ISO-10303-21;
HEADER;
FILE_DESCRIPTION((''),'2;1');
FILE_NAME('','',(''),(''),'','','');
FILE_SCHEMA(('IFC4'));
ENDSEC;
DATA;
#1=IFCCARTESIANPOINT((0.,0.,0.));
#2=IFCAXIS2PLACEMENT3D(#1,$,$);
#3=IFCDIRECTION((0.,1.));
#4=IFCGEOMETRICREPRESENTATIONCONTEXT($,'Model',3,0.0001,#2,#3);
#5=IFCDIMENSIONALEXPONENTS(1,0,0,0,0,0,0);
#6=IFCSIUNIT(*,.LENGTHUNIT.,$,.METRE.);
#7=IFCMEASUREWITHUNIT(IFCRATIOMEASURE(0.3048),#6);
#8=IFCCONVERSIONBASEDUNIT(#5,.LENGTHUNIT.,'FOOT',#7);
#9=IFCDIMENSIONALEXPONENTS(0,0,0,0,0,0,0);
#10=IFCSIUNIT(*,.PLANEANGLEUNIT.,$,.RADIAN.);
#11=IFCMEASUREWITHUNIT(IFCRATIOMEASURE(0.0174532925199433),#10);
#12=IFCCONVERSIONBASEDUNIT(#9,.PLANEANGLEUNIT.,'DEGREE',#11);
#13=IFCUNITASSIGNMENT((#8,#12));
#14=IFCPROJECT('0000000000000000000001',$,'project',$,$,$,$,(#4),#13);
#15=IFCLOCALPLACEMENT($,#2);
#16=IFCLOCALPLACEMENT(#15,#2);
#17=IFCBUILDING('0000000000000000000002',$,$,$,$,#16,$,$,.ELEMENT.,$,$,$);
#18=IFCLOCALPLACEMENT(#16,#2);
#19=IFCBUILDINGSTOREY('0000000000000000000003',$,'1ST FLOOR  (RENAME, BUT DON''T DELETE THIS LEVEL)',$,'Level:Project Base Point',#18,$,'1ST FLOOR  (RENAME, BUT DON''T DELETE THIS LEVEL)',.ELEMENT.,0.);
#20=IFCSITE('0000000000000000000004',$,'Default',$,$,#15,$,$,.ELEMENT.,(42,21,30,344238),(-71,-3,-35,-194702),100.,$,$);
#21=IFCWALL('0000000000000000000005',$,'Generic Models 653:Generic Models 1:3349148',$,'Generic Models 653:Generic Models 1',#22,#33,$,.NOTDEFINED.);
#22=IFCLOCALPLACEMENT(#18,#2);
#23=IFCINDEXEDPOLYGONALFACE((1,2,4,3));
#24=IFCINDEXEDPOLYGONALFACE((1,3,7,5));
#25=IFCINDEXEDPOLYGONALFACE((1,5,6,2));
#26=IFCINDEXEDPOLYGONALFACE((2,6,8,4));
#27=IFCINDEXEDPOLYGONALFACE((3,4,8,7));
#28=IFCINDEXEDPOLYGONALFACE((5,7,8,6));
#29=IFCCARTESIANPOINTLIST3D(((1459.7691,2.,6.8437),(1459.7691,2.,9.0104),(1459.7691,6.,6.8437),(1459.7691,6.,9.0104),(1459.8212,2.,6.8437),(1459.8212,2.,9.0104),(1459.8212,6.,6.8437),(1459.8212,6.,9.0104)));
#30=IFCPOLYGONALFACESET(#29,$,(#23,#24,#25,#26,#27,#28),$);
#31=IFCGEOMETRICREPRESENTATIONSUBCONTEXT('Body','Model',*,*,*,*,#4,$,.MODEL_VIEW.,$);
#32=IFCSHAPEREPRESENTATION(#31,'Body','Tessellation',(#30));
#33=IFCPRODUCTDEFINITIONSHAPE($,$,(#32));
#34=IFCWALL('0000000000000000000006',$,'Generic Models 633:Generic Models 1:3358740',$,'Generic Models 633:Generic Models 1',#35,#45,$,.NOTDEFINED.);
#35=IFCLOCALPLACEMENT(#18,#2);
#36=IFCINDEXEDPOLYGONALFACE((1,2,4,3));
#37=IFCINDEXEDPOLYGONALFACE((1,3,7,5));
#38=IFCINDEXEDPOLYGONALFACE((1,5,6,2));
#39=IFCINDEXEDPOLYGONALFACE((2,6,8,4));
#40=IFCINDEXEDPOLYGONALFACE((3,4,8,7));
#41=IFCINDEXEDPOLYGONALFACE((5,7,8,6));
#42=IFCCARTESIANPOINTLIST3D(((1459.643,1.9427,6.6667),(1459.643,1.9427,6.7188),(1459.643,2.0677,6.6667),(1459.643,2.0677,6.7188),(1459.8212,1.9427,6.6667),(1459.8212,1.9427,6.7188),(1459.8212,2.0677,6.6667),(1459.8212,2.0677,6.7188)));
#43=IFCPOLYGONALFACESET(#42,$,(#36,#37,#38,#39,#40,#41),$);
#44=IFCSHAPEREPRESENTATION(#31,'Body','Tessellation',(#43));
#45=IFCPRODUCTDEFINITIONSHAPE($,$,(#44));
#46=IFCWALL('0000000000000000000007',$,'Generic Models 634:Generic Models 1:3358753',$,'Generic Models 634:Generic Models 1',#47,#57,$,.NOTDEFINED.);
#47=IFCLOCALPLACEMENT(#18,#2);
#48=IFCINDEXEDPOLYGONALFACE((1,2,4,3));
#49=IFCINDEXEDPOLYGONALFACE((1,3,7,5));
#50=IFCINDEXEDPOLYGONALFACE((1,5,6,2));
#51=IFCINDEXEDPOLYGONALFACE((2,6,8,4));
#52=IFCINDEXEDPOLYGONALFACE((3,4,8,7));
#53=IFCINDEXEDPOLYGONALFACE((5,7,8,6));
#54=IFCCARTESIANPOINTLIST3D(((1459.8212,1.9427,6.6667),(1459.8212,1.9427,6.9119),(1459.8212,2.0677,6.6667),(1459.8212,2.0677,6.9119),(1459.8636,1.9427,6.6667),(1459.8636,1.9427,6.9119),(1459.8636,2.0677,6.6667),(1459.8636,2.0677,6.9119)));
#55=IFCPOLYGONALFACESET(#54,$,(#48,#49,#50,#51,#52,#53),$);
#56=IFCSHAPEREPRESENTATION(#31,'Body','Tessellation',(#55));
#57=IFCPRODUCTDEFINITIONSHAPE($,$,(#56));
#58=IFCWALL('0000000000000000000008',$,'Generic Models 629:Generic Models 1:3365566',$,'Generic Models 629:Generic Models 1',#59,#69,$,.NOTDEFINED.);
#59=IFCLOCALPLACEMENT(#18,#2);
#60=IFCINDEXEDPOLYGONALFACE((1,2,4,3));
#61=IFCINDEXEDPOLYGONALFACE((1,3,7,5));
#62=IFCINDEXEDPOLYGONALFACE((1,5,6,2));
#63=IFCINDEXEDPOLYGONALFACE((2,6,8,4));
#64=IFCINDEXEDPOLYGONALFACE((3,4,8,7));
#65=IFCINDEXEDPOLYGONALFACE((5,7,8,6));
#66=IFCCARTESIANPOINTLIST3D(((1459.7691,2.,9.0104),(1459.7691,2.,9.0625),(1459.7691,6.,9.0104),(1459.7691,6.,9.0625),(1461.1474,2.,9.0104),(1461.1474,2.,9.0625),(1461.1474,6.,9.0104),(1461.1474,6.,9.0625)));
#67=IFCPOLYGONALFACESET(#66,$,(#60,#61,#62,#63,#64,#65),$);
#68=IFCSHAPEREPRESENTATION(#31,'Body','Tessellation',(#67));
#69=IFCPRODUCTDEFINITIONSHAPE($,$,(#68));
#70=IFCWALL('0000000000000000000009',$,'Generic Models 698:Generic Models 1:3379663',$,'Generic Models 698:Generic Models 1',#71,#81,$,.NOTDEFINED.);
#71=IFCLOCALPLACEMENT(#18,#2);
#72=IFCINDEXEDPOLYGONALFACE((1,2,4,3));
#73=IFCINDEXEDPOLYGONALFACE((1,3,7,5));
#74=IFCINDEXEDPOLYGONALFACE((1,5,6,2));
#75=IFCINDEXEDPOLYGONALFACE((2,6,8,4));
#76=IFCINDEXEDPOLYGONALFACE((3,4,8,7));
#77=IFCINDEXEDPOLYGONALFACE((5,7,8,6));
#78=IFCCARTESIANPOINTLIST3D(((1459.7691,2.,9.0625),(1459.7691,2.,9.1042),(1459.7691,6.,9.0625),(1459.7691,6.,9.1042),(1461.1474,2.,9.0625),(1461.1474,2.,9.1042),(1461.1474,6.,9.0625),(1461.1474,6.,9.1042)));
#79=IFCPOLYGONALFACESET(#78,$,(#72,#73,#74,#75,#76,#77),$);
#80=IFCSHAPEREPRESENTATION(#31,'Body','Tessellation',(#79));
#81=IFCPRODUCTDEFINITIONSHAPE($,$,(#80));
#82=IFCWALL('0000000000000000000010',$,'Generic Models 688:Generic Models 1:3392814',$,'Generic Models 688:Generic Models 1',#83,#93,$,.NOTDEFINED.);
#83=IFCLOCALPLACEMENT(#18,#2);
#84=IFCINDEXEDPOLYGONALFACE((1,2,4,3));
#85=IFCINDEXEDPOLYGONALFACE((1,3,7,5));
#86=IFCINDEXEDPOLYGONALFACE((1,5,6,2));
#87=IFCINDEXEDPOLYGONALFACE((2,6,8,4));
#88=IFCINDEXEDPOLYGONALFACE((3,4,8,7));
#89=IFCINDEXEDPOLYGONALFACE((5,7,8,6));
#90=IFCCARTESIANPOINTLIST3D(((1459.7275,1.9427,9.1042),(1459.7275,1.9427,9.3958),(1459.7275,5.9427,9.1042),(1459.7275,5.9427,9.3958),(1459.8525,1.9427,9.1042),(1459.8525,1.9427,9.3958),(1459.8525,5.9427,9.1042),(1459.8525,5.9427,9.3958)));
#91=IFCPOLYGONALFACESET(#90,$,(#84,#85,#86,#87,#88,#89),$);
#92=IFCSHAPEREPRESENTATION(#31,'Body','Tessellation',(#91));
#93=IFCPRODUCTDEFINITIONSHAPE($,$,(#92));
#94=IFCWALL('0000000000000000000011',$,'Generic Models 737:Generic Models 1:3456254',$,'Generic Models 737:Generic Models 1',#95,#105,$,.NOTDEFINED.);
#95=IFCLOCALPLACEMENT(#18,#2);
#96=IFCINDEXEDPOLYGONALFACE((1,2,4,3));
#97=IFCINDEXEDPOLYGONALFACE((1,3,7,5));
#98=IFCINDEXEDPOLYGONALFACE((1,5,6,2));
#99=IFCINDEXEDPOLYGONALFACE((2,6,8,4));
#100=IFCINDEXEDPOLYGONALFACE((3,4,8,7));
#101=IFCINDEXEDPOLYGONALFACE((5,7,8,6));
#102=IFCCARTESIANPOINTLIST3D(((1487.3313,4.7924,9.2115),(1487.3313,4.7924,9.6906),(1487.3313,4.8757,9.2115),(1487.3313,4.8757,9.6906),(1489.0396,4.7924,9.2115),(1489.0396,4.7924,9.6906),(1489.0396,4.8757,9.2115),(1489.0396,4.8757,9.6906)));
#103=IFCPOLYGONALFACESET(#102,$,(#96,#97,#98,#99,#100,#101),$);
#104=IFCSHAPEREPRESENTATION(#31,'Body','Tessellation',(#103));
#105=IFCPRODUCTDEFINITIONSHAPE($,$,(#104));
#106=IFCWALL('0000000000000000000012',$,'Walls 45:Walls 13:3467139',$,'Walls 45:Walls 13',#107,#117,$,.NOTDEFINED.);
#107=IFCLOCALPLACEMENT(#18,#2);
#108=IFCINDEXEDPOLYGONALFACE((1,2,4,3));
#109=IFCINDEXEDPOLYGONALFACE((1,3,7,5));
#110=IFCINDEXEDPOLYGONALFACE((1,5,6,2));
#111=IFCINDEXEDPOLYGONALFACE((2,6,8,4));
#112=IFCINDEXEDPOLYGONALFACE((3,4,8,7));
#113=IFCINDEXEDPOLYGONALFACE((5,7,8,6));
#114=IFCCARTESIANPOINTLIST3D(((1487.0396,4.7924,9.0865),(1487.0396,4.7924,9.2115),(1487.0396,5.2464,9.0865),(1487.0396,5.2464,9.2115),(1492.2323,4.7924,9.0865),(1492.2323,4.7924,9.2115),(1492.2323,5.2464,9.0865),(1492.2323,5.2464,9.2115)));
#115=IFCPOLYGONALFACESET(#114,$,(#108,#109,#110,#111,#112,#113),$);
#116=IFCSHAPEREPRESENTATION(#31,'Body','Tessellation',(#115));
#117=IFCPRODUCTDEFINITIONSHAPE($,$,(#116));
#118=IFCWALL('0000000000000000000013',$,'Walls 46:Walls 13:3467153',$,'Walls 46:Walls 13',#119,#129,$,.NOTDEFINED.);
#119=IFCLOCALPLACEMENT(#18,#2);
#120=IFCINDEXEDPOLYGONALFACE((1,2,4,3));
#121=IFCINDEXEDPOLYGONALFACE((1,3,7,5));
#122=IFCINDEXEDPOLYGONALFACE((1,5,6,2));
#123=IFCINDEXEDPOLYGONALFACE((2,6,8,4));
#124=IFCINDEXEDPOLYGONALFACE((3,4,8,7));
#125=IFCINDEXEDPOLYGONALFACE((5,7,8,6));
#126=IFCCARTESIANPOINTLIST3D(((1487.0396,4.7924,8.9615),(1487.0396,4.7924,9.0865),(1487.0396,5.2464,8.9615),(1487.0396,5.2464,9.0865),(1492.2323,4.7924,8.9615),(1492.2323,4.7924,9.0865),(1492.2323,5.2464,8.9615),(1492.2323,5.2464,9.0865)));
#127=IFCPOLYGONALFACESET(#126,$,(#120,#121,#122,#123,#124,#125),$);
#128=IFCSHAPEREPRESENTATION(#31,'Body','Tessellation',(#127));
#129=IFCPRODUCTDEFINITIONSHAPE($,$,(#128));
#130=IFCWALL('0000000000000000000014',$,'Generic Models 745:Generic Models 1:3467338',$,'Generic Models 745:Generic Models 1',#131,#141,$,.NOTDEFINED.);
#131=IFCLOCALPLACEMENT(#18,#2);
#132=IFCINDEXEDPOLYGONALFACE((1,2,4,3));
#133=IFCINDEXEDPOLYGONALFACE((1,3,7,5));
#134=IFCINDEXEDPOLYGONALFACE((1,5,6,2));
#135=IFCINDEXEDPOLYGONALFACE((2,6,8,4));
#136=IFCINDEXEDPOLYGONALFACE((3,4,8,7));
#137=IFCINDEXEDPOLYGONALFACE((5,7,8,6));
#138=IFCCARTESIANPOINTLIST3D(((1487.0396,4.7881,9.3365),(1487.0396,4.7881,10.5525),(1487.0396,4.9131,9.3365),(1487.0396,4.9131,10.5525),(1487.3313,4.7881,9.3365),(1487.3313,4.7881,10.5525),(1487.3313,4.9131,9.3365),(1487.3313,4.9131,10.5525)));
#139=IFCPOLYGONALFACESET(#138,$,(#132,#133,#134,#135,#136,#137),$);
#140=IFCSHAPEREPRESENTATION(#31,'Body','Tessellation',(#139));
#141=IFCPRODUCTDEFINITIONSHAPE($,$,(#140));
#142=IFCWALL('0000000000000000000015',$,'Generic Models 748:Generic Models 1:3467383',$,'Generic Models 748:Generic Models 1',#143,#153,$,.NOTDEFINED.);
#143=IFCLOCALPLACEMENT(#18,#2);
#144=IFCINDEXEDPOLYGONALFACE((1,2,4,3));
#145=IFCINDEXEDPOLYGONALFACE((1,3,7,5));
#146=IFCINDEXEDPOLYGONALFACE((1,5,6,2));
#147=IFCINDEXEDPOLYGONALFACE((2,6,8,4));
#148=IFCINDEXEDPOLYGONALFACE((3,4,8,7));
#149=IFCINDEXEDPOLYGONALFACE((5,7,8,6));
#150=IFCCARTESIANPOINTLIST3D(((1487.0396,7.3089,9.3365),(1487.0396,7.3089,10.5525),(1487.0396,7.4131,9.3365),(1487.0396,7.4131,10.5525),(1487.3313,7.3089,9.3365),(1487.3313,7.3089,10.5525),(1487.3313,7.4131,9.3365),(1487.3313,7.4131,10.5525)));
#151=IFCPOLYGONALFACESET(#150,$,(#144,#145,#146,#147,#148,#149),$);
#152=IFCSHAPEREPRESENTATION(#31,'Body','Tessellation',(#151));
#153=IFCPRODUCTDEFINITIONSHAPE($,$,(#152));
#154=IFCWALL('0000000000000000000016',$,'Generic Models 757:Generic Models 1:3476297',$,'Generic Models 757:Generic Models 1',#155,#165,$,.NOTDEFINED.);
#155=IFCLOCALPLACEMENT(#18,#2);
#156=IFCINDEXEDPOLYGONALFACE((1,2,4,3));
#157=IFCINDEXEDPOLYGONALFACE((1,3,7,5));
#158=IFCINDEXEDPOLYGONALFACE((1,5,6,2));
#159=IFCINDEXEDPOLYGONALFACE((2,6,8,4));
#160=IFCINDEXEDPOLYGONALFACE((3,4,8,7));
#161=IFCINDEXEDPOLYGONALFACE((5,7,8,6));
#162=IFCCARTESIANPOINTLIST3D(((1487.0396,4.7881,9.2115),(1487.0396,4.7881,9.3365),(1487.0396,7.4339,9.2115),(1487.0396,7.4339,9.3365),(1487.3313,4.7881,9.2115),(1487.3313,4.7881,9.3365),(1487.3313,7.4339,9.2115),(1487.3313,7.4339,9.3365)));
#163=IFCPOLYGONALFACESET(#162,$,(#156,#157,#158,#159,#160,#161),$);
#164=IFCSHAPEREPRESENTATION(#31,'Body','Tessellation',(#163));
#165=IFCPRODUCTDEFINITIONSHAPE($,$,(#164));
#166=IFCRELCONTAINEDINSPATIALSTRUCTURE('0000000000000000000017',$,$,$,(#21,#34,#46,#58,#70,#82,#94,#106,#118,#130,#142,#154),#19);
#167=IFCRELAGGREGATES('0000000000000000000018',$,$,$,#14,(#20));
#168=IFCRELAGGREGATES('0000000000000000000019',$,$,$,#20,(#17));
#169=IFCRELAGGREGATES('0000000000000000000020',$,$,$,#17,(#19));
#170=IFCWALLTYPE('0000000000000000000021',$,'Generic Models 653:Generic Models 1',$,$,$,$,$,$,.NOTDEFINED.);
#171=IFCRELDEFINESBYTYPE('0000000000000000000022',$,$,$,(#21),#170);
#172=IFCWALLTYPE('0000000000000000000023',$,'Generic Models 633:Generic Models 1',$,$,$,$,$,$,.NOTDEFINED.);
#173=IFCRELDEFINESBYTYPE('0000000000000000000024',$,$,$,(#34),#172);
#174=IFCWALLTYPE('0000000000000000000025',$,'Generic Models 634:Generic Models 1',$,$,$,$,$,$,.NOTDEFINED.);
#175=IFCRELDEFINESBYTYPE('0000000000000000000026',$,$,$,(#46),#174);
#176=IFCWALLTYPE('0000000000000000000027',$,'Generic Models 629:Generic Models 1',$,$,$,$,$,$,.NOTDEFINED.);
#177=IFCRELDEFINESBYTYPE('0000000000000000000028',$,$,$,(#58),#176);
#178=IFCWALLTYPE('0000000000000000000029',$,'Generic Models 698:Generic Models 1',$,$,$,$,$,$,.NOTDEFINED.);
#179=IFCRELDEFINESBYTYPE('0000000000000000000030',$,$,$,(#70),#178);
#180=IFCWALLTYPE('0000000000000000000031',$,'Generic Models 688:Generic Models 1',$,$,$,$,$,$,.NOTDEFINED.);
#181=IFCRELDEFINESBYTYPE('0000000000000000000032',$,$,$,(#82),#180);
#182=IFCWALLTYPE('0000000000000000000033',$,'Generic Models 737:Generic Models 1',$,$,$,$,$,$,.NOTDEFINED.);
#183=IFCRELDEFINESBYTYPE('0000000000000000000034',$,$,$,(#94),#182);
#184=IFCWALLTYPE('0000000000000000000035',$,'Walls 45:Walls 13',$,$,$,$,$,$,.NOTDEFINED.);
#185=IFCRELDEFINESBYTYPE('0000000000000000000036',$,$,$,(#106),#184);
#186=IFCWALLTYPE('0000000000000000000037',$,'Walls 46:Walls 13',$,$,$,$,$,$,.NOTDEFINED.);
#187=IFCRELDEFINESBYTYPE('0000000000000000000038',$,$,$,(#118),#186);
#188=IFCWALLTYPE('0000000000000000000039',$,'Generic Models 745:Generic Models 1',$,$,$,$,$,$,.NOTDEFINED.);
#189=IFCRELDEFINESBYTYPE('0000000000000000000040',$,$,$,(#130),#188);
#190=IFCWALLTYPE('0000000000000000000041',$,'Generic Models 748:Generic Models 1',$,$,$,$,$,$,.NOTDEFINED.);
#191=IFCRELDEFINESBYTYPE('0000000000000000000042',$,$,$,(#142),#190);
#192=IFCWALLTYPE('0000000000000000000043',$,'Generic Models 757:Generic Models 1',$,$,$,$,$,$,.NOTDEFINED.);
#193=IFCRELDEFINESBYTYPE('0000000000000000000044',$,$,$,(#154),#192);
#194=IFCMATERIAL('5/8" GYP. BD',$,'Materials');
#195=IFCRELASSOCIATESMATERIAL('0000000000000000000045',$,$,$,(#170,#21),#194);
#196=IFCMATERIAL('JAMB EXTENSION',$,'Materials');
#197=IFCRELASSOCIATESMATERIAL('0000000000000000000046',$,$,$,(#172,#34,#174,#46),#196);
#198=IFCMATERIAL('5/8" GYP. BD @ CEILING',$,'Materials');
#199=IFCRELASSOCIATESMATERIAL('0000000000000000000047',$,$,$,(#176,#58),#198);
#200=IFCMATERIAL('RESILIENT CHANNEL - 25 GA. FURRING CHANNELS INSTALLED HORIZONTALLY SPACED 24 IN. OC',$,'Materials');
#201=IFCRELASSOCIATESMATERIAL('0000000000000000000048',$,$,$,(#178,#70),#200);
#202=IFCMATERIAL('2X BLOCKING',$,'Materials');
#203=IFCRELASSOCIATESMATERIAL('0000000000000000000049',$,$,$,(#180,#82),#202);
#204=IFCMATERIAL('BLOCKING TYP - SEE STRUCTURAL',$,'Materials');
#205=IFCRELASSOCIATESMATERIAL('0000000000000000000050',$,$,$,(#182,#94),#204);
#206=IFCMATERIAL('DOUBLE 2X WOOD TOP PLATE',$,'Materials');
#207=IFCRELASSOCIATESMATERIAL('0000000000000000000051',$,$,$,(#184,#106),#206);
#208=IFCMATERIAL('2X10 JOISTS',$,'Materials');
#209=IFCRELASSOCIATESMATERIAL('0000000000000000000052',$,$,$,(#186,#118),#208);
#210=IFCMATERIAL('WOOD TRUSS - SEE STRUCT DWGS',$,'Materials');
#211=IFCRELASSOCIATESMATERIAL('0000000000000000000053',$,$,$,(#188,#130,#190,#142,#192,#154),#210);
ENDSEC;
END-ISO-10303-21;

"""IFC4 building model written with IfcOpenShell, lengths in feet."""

from ifc_helpers import new_model, entity, si_unit, converted_unit, direction, frame, frame_2d, origin, origin_2d_with_axis, place, context, subcontext, project, spatial, rectangle, extrude, material, type_object, element, save


model = new_model("IFC4")

# Units and contexts
model_context = context("Model", 3, precision=0.0001, world=origin(), true_north=direction((0.0, 1.0)))
body_context = subcontext(model_context, "Body", "Model", "MODEL_VIEW")
ifc_project = project(units=[converted_unit("LENGTHUNIT", "FOOT", entity("IfcRatioMeasure", 0.3048), si_unit("LENGTHUNIT", "METRE"), dimensions=[1, 0, 0, 0, 0, 0, 0]), converted_unit("PLANEANGLEUNIT", "DEGREE", entity("IfcRatioMeasure", 0.0174532925199433), si_unit("PLANEANGLEUNIT", "RADIAN"), dimensions=[0, 0, 0, 0, 0, 0, 0])], contexts=[model_context])

# Site, building, storey
site_placement = place(None, origin())
site = spatial("IfcSite", under=ifc_project, at=site_placement, Name="Default", CompositionType="ELEMENT", RefLatitude=(42, 21, 30, 344238), RefLongitude=(-71, -3, -35, -194702), RefElevation=100.0)
building_placement = place(site_placement, origin())
building = spatial("IfcBuilding", under=site, at=building_placement, CompositionType="ELEMENT")
storey_placement = place(building_placement, origin())
storey = spatial("IfcBuildingStorey", under=building, at=storey_placement, Name="1ST FLOOR  (RENAME, BUT DON'T DELETE THIS LEVEL)", ObjectType="Level:Project Base Point", LongName="1ST FLOOR  (RENAME, BUT DON'T DELETE THIS LEVEL)", CompositionType="ELEMENT", Elevation=0.0)

# Walls
ifc_material_1 = material(Name="5/8\" GYP. BD", Category="Materials")
wall_type_1 = type_object("IfcWallType", Name="Generic Models 653:Generic Models 1", PredefinedType="NOTDEFINED", material=ifc_material_1)
wall_1_placement = place(storey_placement, frame((1459.7691, 2.0, 6.8437), z_axis=(0.0, 0.0, 1.0), x_axis=(0.0, 1.0, 0.0)))
element("IfcWall", 1, at=wall_1_placement, inside=storey, type_object=wall_type_1, material=ifc_material_1, Name="Generic Models 653:Generic Models 1:3349148", ObjectType="Generic Models 653:Generic Models 1", PredefinedType="NOTDEFINED", context=body_context, shape_type="SweptSolid", body=[
    extrude(rectangle(XDim=4.0, YDim=0.0521, at=origin_2d_with_axis()), frame((2.0, -0.026, 0.0)), (0.0, 0.0, 1.0), 2.1667),
])
ifc_material_2 = material(Name="JAMB EXTENSION", Category="Materials")
wall_type_2 = type_object("IfcWallType", Name="Generic Models 633:Generic Models 1", PredefinedType="NOTDEFINED", material=ifc_material_2)
wall_2_placement = place(storey_placement, frame((1459.643, 1.9427, 6.6667)))
element("IfcWall", 2, at=wall_2_placement, inside=storey, type_object=wall_type_2, material=ifc_material_2, Name="Generic Models 633:Generic Models 1:3358740", ObjectType="Generic Models 633:Generic Models 1", PredefinedType="NOTDEFINED", context=body_context, shape_type="SweptSolid", body=[
    extrude(rectangle(XDim=0.125, YDim=0.1782, at=frame_2d((0.0, 0.0), x_axis=(1.0, 0.0))), frame((0.0891, 0.0625, 0.0), z_axis=(0.0, 0.0, 1.0), x_axis=(0.0, 1.0, 0.0)), (0.0, 0.0, 1.0), 0.0521),
])
wall_type_3 = type_object("IfcWallType", Name="Generic Models 634:Generic Models 1", PredefinedType="NOTDEFINED", material=ifc_material_2)
wall_3_placement = place(storey_placement, frame((1459.8212, 1.9427, 6.6667), z_axis=(0.0, 0.0, 1.0), x_axis=(0.0, 1.0, 0.0)))
element("IfcWall", 3, at=wall_3_placement, inside=storey, type_object=wall_type_3, material=ifc_material_2, Name="Generic Models 634:Generic Models 1:3358753", ObjectType="Generic Models 634:Generic Models 1", PredefinedType="NOTDEFINED", context=body_context, shape_type="SweptSolid", body=[
    extrude(rectangle(XDim=0.125, YDim=0.0423, at=frame_2d((0.0, 0.0), x_axis=(1.0, 0.0))), frame((0.0625, -0.0212, 0.0)), (0.0, 0.0, 1.0), 0.2452),
])
ifc_material_3 = material(Name="5/8\" GYP. BD @ CEILING", Category="Materials")
wall_type_4 = type_object("IfcWallType", Name="Generic Models 629:Generic Models 1", PredefinedType="NOTDEFINED", material=ifc_material_3)
wall_4_placement = place(storey_placement, frame((1459.7691, 2.0, 9.0104), z_axis=(0.0, 0.0, 1.0), x_axis=(0.0, 1.0, 0.0)))
element("IfcWall", 4, at=wall_4_placement, inside=storey, type_object=wall_type_4, material=ifc_material_3, Name="Generic Models 629:Generic Models 1:3365566", ObjectType="Generic Models 629:Generic Models 1", PredefinedType="NOTDEFINED", context=body_context, shape_type="SweptSolid", body=[
    extrude(rectangle(XDim=4.0, YDim=1.3782, at=frame_2d((0.0, 0.0), x_axis=(1.0, 0.0))), frame((2.0, -0.6891, 0.0)), (0.0, 0.0, 1.0), 0.0521),
])
ifc_material_4 = material(Name="RESILIENT CHANNEL - 25 GA. FURRING CHANNELS INSTALLED HORIZONTALLY SPACED 24 IN. OC", Category="Materials")
wall_type_5 = type_object("IfcWallType", Name="Generic Models 698:Generic Models 1", PredefinedType="NOTDEFINED", material=ifc_material_4)
wall_5_placement = place(storey_placement, frame((1459.7691, 2.0, 9.0625), z_axis=(0.0, 0.0, 1.0), x_axis=(0.0, 1.0, 0.0)))
element("IfcWall", 5, at=wall_5_placement, inside=storey, type_object=wall_type_5, material=ifc_material_4, Name="Generic Models 698:Generic Models 1:3379663", ObjectType="Generic Models 698:Generic Models 1", PredefinedType="NOTDEFINED", context=body_context, shape_type="SweptSolid", body=[
    extrude(rectangle(XDim=4.0, YDim=1.3782, at=frame_2d((0.0, 0.0), x_axis=(1.0, 0.0))), frame((2.0, -0.6891, 0.0)), (0.0, 0.0, 1.0), 0.0417),
])
ifc_material_5 = material(Name="2X BLOCKING", Category="Materials")
wall_type_6 = type_object("IfcWallType", Name="Generic Models 688:Generic Models 1", PredefinedType="NOTDEFINED", material=ifc_material_5)
wall_6_placement = place(storey_placement, frame((1459.7275, 1.9427, 9.1042), z_axis=(0.0, 0.0, 1.0), x_axis=(0.0, 1.0, 0.0)))
element("IfcWall", 6, at=wall_6_placement, inside=storey, type_object=wall_type_6, material=ifc_material_5, Name="Generic Models 688:Generic Models 1:3392814", ObjectType="Generic Models 688:Generic Models 1", PredefinedType="NOTDEFINED", context=body_context, shape_type="SweptSolid", body=[
    extrude(rectangle(XDim=4.0, YDim=0.125, at=frame_2d((0.0, 0.0), x_axis=(1.0, 0.0))), frame((2.0, -0.0625, 0.0)), (0.0, 0.0, 1.0), 0.2917),
])
ifc_material_6 = material(Name="BLOCKING TYP - SEE STRUCTURAL", Category="Materials")
wall_type_7 = type_object("IfcWallType", Name="Generic Models 737:Generic Models 1", PredefinedType="NOTDEFINED", material=ifc_material_6)
wall_7_placement = place(storey_placement, frame((1487.3313, 4.7924, 9.2115)))
element("IfcWall", 7, at=wall_7_placement, inside=storey, type_object=wall_type_7, material=ifc_material_6, Name="Generic Models 737:Generic Models 1:3456254", ObjectType="Generic Models 737:Generic Models 1", PredefinedType="NOTDEFINED", context=body_context, shape_type="SweptSolid", body=[
    extrude(rectangle(XDim=0.0833, YDim=1.7083, at=frame_2d((0.0, 0.0), x_axis=(1.0, 0.0))), frame((0.8542, 0.0417, 0.0), z_axis=(0.0, 0.0, 1.0), x_axis=(0.0, 1.0, 0.0)), (0.0, 0.0, 1.0), 0.4792),
])
ifc_material_7 = material(Name="DOUBLE 2X WOOD TOP PLATE", Category="Materials")
wall_type_8 = type_object("IfcWallType", Name="Walls 45:Walls 13", PredefinedType="NOTDEFINED", material=ifc_material_7)
wall_8_placement = place(storey_placement, frame((1487.0396, 4.7924, 9.0865)))
element("IfcWall", 8, at=wall_8_placement, inside=storey, type_object=wall_type_8, material=ifc_material_7, Name="Walls 45:Walls 13:3467139", ObjectType="Walls 45:Walls 13", PredefinedType="NOTDEFINED", context=body_context, shape_type="SweptSolid", body=[
    extrude(rectangle(XDim=0.454, YDim=5.1927, at=frame_2d((0.0, 0.0), x_axis=(1.0, 0.0))), frame((2.5964, 0.227, 0.0), z_axis=(0.0, 0.0, 1.0), x_axis=(0.0, 1.0, 0.0)), (0.0, 0.0, 1.0), 0.125),
])
ifc_material_8 = material(Name="2X10 JOISTS", Category="Materials")
wall_type_9 = type_object("IfcWallType", Name="Walls 46:Walls 13", PredefinedType="NOTDEFINED", material=ifc_material_8)
wall_9_placement = place(storey_placement, frame((1487.0396, 4.7924, 8.9615)))
element("IfcWall", 9, at=wall_9_placement, inside=storey, type_object=wall_type_9, material=ifc_material_8, Name="Walls 46:Walls 13:3467153", ObjectType="Walls 46:Walls 13", PredefinedType="NOTDEFINED", context=body_context, shape_type="SweptSolid", body=[
    extrude(rectangle(XDim=0.454, YDim=5.1927, at=frame_2d((0.0, 0.0), x_axis=(1.0, 0.0))), frame((2.5964, 0.227, 0.0), z_axis=(0.0, 0.0, 1.0), x_axis=(0.0, 1.0, 0.0)), (0.0, 0.0, 1.0), 0.125),
])
ifc_material_9 = material(Name="WOOD TRUSS - SEE STRUCT DWGS", Category="Materials")
wall_type_10 = type_object("IfcWallType", Name="Generic Models 745:Generic Models 1", PredefinedType="NOTDEFINED", material=ifc_material_9)
wall_10_placement = place(storey_placement, frame((1487.0396, 4.7881, 9.3365)))
element("IfcWall", 10, at=wall_10_placement, inside=storey, type_object=wall_type_10, material=ifc_material_9, Name="Generic Models 745:Generic Models 1:3467338", ObjectType="Generic Models 745:Generic Models 1", PredefinedType="NOTDEFINED", context=body_context, shape_type="SweptSolid", body=[
    extrude(rectangle(XDim=0.125, YDim=0.2917, at=frame_2d((0.0, 0.0), x_axis=(1.0, 0.0))), frame((0.1458, 0.0625, 0.0), z_axis=(0.0, 0.0, 1.0), x_axis=(0.0, 1.0, 0.0)), (0.0, 0.0, 1.0), 1.2161),
])
wall_type_11 = type_object("IfcWallType", Name="Generic Models 748:Generic Models 1", PredefinedType="NOTDEFINED", material=ifc_material_9)
wall_11_placement = place(storey_placement, frame((1487.0396, 7.3089, 9.3365)))
element("IfcWall", 11, at=wall_11_placement, inside=storey, type_object=wall_type_11, material=ifc_material_9, Name="Generic Models 748:Generic Models 1:3467383", ObjectType="Generic Models 748:Generic Models 1", PredefinedType="NOTDEFINED", context=body_context, shape_type="SweptSolid", body=[
    extrude(rectangle(XDim=0.1042, YDim=0.2917, at=frame_2d((0.0, 0.0), x_axis=(1.0, 0.0))), frame((0.1458, 0.0521, 0.0), z_axis=(0.0, 0.0, 1.0), x_axis=(0.0, 1.0, 0.0)), (0.0, 0.0, 1.0), 1.2161),
])
wall_type_12 = type_object("IfcWallType", Name="Generic Models 757:Generic Models 1", PredefinedType="NOTDEFINED", material=ifc_material_9)
wall_12_placement = place(storey_placement, frame((1487.0396, 4.7881, 9.2115), z_axis=(0.0, 0.0, 1.0), x_axis=(0.0, 1.0, 0.0)))
element("IfcWall", 12, at=wall_12_placement, inside=storey, type_object=wall_type_12, material=ifc_material_9, Name="Generic Models 757:Generic Models 1:3476297", ObjectType="Generic Models 757:Generic Models 1", PredefinedType="NOTDEFINED", context=body_context, shape_type="SweptSolid", body=[
    extrude(rectangle(XDim=2.6458, YDim=0.2917, at=origin_2d_with_axis()), frame((1.3229, -0.1458, 0.0)), (0.0, 0.0, 1.0), 0.125),
])

save(model, "model.ifc")
